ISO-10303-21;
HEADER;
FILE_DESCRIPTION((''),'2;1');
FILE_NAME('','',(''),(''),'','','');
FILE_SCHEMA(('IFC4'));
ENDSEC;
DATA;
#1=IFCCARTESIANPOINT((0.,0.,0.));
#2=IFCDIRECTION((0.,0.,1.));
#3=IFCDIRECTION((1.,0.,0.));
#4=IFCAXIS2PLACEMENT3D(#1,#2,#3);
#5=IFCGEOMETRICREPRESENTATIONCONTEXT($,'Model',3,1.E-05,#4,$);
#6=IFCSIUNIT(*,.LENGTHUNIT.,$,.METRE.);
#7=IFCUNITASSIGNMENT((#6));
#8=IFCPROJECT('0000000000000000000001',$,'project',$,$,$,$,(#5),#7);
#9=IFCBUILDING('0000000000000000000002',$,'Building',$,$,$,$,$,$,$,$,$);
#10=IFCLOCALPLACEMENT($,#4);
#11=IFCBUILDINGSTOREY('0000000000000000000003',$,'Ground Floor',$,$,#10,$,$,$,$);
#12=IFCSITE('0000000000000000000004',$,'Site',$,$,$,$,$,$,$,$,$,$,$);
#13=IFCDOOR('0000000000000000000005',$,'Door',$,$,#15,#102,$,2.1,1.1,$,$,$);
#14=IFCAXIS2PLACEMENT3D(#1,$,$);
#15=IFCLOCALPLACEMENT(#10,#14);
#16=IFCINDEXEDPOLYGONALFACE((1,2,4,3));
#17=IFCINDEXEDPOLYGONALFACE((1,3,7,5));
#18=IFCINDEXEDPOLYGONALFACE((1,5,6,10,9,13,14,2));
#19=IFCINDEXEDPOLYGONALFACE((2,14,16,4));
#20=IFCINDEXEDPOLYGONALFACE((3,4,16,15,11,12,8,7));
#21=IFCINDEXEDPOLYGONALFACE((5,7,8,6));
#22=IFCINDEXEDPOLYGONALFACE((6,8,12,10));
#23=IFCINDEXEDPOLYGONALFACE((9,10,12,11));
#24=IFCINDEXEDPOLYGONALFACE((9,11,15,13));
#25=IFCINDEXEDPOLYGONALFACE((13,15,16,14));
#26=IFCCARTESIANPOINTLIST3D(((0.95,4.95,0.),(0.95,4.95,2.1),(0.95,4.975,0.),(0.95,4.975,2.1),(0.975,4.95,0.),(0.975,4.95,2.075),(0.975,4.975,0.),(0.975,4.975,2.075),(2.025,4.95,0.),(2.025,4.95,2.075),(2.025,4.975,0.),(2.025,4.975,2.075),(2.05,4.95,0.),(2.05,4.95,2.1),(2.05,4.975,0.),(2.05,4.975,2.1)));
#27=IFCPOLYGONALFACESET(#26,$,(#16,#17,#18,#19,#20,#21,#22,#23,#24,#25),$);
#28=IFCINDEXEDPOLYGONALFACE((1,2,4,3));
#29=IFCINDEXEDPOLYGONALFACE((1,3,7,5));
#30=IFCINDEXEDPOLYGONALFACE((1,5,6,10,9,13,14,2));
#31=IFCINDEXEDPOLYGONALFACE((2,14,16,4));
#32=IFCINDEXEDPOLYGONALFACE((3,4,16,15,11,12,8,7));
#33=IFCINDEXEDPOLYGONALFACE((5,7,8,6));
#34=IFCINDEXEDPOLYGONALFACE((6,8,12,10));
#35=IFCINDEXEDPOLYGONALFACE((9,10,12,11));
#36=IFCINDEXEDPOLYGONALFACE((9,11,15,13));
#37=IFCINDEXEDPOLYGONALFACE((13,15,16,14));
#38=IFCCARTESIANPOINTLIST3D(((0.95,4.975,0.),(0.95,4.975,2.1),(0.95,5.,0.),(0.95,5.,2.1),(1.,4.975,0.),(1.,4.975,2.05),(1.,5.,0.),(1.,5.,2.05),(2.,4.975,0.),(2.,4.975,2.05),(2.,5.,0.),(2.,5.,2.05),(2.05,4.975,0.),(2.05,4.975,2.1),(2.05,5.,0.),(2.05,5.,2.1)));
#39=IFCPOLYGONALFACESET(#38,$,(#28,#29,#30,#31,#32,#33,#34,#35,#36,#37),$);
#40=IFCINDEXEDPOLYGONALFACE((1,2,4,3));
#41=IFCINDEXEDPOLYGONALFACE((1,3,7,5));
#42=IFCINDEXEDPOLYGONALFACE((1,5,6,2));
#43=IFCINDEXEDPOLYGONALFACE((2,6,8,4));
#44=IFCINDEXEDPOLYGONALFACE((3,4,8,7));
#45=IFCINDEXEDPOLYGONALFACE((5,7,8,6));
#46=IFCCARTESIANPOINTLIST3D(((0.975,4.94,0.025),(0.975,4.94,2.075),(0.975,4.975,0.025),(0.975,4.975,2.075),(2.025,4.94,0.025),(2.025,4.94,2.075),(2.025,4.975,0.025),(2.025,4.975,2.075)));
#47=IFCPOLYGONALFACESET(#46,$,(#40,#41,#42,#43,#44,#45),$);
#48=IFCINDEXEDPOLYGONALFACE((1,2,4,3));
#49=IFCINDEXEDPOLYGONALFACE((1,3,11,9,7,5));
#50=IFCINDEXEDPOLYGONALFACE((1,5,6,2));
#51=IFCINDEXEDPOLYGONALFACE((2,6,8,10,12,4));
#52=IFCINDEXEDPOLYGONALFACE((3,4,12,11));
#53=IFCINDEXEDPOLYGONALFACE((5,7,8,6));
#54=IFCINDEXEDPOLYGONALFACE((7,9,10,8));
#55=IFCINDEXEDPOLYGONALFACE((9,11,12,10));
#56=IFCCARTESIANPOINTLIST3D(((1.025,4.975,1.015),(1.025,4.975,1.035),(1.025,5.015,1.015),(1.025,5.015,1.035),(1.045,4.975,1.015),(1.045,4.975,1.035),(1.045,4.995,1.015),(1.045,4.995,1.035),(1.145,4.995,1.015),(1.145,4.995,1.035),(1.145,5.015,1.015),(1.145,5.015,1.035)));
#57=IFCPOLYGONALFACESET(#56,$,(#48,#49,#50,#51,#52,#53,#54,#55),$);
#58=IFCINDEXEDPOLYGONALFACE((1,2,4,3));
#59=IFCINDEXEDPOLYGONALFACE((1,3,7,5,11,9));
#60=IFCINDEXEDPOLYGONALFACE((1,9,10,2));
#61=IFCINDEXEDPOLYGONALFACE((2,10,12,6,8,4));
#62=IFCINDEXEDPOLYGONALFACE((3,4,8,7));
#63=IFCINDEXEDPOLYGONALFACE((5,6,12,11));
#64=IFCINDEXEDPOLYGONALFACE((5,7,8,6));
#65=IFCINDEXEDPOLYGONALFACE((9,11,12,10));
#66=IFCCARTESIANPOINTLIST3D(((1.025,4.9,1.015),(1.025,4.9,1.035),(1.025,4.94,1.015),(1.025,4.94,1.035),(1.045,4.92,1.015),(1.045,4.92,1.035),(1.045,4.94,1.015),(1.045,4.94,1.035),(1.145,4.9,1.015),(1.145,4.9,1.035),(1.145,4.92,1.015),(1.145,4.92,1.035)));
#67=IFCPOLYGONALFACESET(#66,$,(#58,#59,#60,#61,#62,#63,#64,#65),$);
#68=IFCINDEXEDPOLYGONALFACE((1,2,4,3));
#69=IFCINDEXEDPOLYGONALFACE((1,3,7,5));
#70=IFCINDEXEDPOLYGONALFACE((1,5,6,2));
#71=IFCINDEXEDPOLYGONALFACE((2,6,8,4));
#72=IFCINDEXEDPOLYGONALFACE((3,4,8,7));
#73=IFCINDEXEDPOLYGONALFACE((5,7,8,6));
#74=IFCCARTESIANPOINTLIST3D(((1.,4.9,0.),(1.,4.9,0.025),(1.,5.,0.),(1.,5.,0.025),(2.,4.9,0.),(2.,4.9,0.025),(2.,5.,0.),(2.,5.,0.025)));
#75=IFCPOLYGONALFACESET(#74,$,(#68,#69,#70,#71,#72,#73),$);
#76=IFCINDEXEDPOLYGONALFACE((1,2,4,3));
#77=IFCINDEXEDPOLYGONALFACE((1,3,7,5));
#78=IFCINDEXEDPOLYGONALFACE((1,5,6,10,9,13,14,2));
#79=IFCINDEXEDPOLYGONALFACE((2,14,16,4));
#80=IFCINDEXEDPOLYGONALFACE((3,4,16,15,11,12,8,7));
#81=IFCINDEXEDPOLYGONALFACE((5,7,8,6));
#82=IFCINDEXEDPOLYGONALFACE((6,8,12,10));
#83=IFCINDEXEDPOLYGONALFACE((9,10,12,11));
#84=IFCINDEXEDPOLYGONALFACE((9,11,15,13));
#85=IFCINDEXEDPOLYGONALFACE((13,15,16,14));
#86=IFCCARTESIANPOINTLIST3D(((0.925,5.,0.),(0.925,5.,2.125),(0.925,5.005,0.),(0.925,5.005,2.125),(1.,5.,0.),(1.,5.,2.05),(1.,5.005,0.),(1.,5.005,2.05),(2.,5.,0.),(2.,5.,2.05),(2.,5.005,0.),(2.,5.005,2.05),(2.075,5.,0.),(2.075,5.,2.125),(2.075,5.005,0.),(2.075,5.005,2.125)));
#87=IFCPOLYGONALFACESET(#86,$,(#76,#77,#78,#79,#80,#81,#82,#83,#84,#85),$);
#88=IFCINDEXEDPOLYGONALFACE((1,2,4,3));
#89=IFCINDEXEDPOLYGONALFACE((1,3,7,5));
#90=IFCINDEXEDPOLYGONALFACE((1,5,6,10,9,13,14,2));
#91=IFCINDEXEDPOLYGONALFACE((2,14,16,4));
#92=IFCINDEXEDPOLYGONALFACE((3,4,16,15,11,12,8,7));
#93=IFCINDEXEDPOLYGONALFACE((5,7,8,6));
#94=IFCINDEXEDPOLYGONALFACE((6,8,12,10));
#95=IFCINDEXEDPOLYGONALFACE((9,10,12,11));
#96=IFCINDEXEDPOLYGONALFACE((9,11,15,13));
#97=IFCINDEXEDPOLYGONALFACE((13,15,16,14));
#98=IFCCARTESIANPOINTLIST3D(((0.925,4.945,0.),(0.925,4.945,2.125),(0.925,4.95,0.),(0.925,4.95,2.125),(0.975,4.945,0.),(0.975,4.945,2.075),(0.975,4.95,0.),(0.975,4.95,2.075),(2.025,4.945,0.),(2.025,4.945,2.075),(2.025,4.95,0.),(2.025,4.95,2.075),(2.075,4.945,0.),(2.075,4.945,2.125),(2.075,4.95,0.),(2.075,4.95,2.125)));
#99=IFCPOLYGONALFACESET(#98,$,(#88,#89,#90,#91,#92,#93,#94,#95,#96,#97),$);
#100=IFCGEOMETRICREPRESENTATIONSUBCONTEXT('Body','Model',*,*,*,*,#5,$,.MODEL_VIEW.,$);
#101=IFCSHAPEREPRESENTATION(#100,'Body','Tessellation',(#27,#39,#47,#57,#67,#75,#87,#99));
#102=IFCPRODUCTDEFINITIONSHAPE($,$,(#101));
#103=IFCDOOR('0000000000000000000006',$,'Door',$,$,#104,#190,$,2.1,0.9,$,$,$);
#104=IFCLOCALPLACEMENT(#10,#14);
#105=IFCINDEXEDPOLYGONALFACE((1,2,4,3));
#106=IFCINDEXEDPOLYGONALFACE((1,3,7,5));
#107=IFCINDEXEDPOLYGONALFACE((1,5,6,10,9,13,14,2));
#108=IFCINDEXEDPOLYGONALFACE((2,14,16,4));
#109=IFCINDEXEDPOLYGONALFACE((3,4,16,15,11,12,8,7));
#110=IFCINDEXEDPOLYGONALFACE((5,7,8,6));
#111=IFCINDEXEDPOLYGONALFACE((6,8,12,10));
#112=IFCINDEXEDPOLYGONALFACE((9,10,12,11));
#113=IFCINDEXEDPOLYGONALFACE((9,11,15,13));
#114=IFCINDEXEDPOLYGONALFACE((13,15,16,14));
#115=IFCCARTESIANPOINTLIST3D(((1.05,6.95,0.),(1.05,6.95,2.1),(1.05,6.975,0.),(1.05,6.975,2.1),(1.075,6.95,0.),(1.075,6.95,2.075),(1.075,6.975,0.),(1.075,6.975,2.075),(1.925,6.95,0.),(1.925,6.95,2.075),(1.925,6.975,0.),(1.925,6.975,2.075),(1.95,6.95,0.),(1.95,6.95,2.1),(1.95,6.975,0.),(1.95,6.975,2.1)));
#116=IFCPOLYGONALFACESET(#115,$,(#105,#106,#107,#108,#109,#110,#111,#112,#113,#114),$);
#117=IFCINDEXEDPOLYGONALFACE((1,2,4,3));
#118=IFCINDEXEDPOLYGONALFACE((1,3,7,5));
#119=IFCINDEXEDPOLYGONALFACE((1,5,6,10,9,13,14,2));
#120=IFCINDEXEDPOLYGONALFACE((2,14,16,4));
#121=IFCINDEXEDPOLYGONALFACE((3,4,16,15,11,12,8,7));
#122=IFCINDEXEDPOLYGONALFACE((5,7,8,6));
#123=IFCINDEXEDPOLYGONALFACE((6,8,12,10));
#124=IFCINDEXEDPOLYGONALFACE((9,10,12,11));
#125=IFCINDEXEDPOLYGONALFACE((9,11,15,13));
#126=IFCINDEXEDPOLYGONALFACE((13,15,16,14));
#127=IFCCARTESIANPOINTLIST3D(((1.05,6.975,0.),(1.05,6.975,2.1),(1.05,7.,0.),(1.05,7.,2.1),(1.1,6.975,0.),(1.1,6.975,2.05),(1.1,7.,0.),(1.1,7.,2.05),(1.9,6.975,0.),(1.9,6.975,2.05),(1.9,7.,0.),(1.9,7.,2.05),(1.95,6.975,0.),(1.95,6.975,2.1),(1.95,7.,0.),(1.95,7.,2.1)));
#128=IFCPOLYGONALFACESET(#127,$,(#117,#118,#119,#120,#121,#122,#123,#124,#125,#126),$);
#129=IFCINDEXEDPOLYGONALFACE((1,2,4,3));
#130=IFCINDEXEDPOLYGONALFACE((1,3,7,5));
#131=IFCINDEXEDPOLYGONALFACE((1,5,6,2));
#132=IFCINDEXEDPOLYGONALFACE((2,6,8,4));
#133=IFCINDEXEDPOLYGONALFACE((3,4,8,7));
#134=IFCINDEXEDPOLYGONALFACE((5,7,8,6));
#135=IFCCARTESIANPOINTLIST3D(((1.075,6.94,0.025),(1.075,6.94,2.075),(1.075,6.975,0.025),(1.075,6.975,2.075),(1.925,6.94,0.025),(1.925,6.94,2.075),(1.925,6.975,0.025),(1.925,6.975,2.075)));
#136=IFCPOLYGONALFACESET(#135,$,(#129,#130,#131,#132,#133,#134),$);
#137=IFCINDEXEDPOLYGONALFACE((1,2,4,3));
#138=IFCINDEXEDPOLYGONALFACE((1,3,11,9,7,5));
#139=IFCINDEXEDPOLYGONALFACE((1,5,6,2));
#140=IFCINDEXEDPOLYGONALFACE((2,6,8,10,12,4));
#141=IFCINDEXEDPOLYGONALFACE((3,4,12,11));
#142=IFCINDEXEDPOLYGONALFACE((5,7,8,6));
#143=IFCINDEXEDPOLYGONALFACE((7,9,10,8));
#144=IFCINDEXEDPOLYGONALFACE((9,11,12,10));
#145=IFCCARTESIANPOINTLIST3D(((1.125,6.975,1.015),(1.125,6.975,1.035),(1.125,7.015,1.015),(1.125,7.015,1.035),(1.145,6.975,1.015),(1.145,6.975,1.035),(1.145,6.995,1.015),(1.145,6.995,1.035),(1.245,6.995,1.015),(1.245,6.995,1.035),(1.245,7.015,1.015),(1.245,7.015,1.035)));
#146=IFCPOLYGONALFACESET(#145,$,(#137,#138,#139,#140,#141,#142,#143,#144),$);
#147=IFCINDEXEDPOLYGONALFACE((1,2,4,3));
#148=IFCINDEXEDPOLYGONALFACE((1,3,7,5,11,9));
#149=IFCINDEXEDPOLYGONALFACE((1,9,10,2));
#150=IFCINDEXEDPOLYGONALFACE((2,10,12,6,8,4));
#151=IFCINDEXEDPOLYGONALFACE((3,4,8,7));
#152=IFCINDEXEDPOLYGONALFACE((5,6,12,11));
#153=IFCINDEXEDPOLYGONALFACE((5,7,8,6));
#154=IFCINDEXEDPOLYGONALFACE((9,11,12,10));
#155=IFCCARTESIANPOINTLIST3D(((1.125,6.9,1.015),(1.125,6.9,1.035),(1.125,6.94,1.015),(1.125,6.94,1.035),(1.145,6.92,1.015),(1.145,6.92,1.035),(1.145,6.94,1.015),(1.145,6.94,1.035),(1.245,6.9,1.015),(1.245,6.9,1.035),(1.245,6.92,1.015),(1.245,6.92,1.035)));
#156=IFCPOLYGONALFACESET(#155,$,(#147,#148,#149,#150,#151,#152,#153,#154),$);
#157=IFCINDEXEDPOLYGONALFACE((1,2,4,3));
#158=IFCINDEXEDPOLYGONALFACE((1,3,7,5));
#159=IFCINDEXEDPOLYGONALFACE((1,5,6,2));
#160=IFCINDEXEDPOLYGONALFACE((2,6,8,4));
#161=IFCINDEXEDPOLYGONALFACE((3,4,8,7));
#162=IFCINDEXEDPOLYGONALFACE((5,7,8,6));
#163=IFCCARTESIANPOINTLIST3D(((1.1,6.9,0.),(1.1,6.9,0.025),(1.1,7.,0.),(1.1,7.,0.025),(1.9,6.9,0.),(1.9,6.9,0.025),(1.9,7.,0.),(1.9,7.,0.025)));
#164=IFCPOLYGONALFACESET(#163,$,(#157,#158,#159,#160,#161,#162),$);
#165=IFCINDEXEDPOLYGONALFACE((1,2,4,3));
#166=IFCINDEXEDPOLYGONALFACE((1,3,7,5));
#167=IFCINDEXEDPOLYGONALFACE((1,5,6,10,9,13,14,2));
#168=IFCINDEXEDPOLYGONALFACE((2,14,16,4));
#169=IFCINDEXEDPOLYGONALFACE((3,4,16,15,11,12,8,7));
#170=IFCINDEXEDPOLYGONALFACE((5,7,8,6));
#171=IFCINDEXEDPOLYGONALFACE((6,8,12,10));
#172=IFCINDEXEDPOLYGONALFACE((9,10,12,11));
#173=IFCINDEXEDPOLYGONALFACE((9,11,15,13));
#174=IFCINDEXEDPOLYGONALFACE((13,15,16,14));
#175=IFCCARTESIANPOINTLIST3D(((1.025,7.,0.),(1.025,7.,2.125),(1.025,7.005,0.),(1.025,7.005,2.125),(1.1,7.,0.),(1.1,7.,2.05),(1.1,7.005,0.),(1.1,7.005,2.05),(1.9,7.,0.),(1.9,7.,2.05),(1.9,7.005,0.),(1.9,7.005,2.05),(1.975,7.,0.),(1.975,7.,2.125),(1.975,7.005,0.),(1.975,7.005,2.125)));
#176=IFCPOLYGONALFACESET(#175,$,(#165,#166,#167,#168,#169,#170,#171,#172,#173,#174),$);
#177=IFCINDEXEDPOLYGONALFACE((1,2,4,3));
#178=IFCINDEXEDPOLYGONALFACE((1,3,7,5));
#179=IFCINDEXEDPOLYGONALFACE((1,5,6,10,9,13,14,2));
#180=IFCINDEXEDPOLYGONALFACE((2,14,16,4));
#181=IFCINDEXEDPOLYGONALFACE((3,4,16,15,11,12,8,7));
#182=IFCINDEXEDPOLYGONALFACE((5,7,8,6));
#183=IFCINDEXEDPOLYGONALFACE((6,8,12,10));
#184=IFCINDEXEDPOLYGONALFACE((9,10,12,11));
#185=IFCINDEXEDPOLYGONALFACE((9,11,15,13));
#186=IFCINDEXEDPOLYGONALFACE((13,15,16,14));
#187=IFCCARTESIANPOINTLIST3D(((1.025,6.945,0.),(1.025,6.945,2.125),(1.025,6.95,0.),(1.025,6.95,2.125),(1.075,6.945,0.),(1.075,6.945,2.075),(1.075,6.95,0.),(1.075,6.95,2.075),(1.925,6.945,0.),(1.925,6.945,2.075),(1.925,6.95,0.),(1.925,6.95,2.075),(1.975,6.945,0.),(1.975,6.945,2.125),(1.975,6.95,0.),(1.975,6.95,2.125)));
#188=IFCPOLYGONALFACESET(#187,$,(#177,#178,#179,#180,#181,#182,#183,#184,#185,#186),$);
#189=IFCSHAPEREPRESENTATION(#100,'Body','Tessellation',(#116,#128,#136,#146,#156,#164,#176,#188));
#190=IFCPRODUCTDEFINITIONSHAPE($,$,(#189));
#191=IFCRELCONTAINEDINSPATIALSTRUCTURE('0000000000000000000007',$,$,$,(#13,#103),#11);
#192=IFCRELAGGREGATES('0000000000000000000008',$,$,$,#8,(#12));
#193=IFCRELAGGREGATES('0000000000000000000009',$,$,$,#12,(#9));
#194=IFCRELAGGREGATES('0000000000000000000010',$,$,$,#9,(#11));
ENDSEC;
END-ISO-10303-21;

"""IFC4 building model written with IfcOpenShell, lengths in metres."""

from ifc_helpers import new_model, si_unit, frame, origin_with_axes, place, context, subcontext, project, spatial, line, indexed_curve, outline, extrude, element, save


model = new_model("IFC4")

# Units and contexts
model_context = context("Model", 3, precision=1e-05, world=origin_with_axes())
body_context = subcontext(model_context, "Body", "Model", "MODEL_VIEW")
ifc_project = project(units=[si_unit("LENGTHUNIT", "METRE")], contexts=[model_context])

# Site, building, storey
site = spatial("IfcSite", under=ifc_project, Name="Site")
building = spatial("IfcBuilding", under=site, Name="Building")
storey_placement = place(None, origin_with_axes())
storey = spatial("IfcBuildingStorey", under=building, at=storey_placement, Name="Ground Floor")

# Doors
door_1_placement = place(storey_placement, frame((2.05, 5.0, 0.0), z_axis=(0.0, 0.0, 1.0), x_axis=(-1.0, 0.0, 0.0)))
element("IfcDoor", 1, at=door_1_placement, inside=storey, Name="Door", OverallHeight=2.1, OverallWidth=1.1, context=body_context, shape_type="SweptSolid", body=[
    extrude(outline(indexed_curve([(0.0, 0.0), (0.0, 2.1), (1.1, 2.1), (1.1, 0.0), (1.075, 0.0), (1.075, 2.075), (0.025, 2.075), (0.025, 0.0)], segments=[line(1, 2, 3, 4, 5, 6, 7, 8, 1)])), frame((0.0, 0.025, 0.0), z_axis=(0.0, -1.0, 0.0), x_axis=(1.0, 0.0, 0.0)), (0.0, 0.0, -1.0), 0.025),
    extrude(outline(indexed_curve([(0.0, 0.0), (0.0, 2.1), (1.1, 2.1), (1.1, 0.0), (1.05, 0.0), (1.05, 2.05), (0.05, 2.05), (0.05, 0.0)], segments=[line(1, 2, 3, 4, 5, 6, 7, 8, 1)])), frame((0.0, 0.0, 0.0), z_axis=(0.0, -1.0, 0.0), x_axis=(1.0, 0.0, 0.0)), (0.0, 0.0, -1.0), 0.025),
    extrude(outline(indexed_curve([(0.0, 0.0), (1.05, 0.0), (1.05, 0.035), (0.0, 0.035)], segments=[line(1, 2, 3, 4, 1)])), frame((0.025, 0.025, 0.025), z_axis=(0.0, 0.0, 1.0), x_axis=(1.0, 0.0, 0.0)), (0.0, 0.0, 1.0), 2.05),
    extrude(outline(indexed_curve([(0.0, 0.0), (0.0, -0.04), (-0.12, -0.04), (-0.12, -0.02), (-0.02, -0.02), (-0.02, 0.0)], segments=[line(1, 2, 3, 4, 5, 6, 1)])), frame((1.025, 0.025, 1.015), z_axis=(0.0, 0.0, 1.0), x_axis=(1.0, 0.0, 0.0)), (0.0, 0.0, 1.0), 0.02),
    extrude(outline(indexed_curve([(0.0, 0.0), (0.0, 0.04), (-0.12, 0.04), (-0.12, 0.02), (-0.02, 0.02), (-0.02, 0.0)], segments=[line(1, 2, 3, 4, 5, 6, 1)])), frame((1.025, 0.06, 1.015), z_axis=(0.0, 0.0, 1.0), x_axis=(1.0, 0.0, 0.0)), (0.0, 0.0, 1.0), 0.02),
    extrude(outline(indexed_curve([(0.0, 0.0), (1.0, 0.0), (1.0, 0.1), (0.0, 0.1)], segments=[line(1, 2, 3, 4, 1)])), frame((0.05, 0.0, 0.0), z_axis=(0.0, 0.0, 1.0), x_axis=(1.0, 0.0, 0.0)), (0.0, 0.0, 1.0), 0.025),
    extrude(outline(indexed_curve([(0.0, 0.0), (0.0, 2.125), (1.15, 2.125), (1.15, 0.0), (1.075, 0.0), (1.075, 2.05), (0.075, 2.05), (0.075, 0.0)], segments=[line(1, 2, 3, 4, 5, 6, 7, 8, 1)])), frame((-0.025, -0.005, 0.0), z_axis=(0.0, -1.0, 0.0), x_axis=(1.0, 0.0, 0.0)), (0.0, 0.0, -1.0), 0.005),
    extrude(outline(indexed_curve([(0.0, 0.0), (0.0, 2.125), (1.15, 2.125), (1.15, 0.0), (1.1, 0.0), (1.1, 2.075), (0.05, 2.075), (0.05, 0.0)], segments=[line(1, 2, 3, 4, 5, 6, 7, 8, 1)])), frame((-0.025, 0.05, 0.0), z_axis=(0.0, -1.0, 0.0), x_axis=(1.0, 0.0, 0.0)), (0.0, 0.0, -1.0), 0.005),
])
door_2_placement = place(storey_placement, frame((1.95, 7.0, 0.0), z_axis=(0.0, 0.0, 1.0), x_axis=(-1.0, 0.0, 0.0)))
element("IfcDoor", 2, at=door_2_placement, inside=storey, Name="Door", OverallHeight=2.1, OverallWidth=0.9, context=body_context, shape_type="SweptSolid", body=[
    extrude(outline(indexed_curve([(0.0, 0.0), (0.0, 2.1), (0.9, 2.1), (0.9, 0.0), (0.875, 0.0), (0.875, 2.075), (0.025, 2.075), (0.025, 0.0)], segments=[line(1, 2, 3, 4, 5, 6, 7, 8, 1)])), frame((0.0, 0.025, 0.0), z_axis=(0.0, -1.0, 0.0), x_axis=(1.0, 0.0, 0.0)), (0.0, 0.0, -1.0), 0.025),
    extrude(outline(indexed_curve([(0.0, 0.0), (0.0, 2.1), (0.9, 2.1), (0.9, 0.0), (0.85, 0.0), (0.85, 2.05), (0.05, 2.05), (0.05, 0.0)], segments=[line(1, 2, 3, 4, 5, 6, 7, 8, 1)])), frame((0.0, 0.0, 0.0), z_axis=(0.0, -1.0, 0.0), x_axis=(1.0, 0.0, 0.0)), (0.0, 0.0, -1.0), 0.025),
    extrude(outline(indexed_curve([(0.0, 0.0), (0.85, 0.0), (0.85, 0.035), (0.0, 0.035)], segments=[line(1, 2, 3, 4, 1)])), frame((0.025, 0.025, 0.025), z_axis=(0.0, 0.0, 1.0), x_axis=(1.0, 0.0, 0.0)), (0.0, 0.0, 1.0), 2.05),
    extrude(outline(indexed_curve([(0.0, 0.0), (0.0, -0.04), (-0.12, -0.04), (-0.12, -0.02), (-0.02, -0.02), (-0.02, 0.0)], segments=[line(1, 2, 3, 4, 5, 6, 1)])), frame((0.825, 0.025, 1.015), z_axis=(0.0, 0.0, 1.0), x_axis=(1.0, 0.0, 0.0)), (0.0, 0.0, 1.0), 0.02),
    extrude(outline(indexed_curve([(0.0, 0.0), (0.0, 0.04), (-0.12, 0.04), (-0.12, 0.02), (-0.02, 0.02), (-0.02, 0.0)], segments=[line(1, 2, 3, 4, 5, 6, 1)])), frame((0.825, 0.06, 1.015), z_axis=(0.0, 0.0, 1.0), x_axis=(1.0, 0.0, 0.0)), (0.0, 0.0, 1.0), 0.02),
    extrude(outline(indexed_curve([(0.0, 0.0), (0.8, 0.0), (0.8, 0.1), (0.0, 0.1)], segments=[line(1, 2, 3, 4, 1)])), frame((0.05, 0.0, 0.0), z_axis=(0.0, 0.0, 1.0), x_axis=(1.0, 0.0, 0.0)), (0.0, 0.0, 1.0), 0.025),
    extrude(outline(indexed_curve([(0.0, 0.0), (0.0, 2.125), (0.95, 2.125), (0.95, 0.0), (0.875, 0.0), (0.875, 2.05), (0.075, 2.05), (0.075, 0.0)], segments=[line(1, 2, 3, 4, 5, 6, 7, 8, 1)])), frame((-0.025, -0.005, 0.0), z_axis=(0.0, -1.0, 0.0), x_axis=(1.0, 0.0, 0.0)), (0.0, 0.0, -1.0), 0.005),
    extrude(outline(indexed_curve([(0.0, 0.0), (0.0, 2.125), (0.95, 2.125), (0.95, 0.0), (0.9, 0.0), (0.9, 2.075), (0.05, 2.075), (0.05, 0.0)], segments=[line(1, 2, 3, 4, 5, 6, 7, 8, 1)])), frame((-0.025, 0.05, 0.0), z_axis=(0.0, -1.0, 0.0), x_axis=(1.0, 0.0, 0.0)), (0.0, 0.0, -1.0), 0.005),
])

save(model, "model.ifc")
